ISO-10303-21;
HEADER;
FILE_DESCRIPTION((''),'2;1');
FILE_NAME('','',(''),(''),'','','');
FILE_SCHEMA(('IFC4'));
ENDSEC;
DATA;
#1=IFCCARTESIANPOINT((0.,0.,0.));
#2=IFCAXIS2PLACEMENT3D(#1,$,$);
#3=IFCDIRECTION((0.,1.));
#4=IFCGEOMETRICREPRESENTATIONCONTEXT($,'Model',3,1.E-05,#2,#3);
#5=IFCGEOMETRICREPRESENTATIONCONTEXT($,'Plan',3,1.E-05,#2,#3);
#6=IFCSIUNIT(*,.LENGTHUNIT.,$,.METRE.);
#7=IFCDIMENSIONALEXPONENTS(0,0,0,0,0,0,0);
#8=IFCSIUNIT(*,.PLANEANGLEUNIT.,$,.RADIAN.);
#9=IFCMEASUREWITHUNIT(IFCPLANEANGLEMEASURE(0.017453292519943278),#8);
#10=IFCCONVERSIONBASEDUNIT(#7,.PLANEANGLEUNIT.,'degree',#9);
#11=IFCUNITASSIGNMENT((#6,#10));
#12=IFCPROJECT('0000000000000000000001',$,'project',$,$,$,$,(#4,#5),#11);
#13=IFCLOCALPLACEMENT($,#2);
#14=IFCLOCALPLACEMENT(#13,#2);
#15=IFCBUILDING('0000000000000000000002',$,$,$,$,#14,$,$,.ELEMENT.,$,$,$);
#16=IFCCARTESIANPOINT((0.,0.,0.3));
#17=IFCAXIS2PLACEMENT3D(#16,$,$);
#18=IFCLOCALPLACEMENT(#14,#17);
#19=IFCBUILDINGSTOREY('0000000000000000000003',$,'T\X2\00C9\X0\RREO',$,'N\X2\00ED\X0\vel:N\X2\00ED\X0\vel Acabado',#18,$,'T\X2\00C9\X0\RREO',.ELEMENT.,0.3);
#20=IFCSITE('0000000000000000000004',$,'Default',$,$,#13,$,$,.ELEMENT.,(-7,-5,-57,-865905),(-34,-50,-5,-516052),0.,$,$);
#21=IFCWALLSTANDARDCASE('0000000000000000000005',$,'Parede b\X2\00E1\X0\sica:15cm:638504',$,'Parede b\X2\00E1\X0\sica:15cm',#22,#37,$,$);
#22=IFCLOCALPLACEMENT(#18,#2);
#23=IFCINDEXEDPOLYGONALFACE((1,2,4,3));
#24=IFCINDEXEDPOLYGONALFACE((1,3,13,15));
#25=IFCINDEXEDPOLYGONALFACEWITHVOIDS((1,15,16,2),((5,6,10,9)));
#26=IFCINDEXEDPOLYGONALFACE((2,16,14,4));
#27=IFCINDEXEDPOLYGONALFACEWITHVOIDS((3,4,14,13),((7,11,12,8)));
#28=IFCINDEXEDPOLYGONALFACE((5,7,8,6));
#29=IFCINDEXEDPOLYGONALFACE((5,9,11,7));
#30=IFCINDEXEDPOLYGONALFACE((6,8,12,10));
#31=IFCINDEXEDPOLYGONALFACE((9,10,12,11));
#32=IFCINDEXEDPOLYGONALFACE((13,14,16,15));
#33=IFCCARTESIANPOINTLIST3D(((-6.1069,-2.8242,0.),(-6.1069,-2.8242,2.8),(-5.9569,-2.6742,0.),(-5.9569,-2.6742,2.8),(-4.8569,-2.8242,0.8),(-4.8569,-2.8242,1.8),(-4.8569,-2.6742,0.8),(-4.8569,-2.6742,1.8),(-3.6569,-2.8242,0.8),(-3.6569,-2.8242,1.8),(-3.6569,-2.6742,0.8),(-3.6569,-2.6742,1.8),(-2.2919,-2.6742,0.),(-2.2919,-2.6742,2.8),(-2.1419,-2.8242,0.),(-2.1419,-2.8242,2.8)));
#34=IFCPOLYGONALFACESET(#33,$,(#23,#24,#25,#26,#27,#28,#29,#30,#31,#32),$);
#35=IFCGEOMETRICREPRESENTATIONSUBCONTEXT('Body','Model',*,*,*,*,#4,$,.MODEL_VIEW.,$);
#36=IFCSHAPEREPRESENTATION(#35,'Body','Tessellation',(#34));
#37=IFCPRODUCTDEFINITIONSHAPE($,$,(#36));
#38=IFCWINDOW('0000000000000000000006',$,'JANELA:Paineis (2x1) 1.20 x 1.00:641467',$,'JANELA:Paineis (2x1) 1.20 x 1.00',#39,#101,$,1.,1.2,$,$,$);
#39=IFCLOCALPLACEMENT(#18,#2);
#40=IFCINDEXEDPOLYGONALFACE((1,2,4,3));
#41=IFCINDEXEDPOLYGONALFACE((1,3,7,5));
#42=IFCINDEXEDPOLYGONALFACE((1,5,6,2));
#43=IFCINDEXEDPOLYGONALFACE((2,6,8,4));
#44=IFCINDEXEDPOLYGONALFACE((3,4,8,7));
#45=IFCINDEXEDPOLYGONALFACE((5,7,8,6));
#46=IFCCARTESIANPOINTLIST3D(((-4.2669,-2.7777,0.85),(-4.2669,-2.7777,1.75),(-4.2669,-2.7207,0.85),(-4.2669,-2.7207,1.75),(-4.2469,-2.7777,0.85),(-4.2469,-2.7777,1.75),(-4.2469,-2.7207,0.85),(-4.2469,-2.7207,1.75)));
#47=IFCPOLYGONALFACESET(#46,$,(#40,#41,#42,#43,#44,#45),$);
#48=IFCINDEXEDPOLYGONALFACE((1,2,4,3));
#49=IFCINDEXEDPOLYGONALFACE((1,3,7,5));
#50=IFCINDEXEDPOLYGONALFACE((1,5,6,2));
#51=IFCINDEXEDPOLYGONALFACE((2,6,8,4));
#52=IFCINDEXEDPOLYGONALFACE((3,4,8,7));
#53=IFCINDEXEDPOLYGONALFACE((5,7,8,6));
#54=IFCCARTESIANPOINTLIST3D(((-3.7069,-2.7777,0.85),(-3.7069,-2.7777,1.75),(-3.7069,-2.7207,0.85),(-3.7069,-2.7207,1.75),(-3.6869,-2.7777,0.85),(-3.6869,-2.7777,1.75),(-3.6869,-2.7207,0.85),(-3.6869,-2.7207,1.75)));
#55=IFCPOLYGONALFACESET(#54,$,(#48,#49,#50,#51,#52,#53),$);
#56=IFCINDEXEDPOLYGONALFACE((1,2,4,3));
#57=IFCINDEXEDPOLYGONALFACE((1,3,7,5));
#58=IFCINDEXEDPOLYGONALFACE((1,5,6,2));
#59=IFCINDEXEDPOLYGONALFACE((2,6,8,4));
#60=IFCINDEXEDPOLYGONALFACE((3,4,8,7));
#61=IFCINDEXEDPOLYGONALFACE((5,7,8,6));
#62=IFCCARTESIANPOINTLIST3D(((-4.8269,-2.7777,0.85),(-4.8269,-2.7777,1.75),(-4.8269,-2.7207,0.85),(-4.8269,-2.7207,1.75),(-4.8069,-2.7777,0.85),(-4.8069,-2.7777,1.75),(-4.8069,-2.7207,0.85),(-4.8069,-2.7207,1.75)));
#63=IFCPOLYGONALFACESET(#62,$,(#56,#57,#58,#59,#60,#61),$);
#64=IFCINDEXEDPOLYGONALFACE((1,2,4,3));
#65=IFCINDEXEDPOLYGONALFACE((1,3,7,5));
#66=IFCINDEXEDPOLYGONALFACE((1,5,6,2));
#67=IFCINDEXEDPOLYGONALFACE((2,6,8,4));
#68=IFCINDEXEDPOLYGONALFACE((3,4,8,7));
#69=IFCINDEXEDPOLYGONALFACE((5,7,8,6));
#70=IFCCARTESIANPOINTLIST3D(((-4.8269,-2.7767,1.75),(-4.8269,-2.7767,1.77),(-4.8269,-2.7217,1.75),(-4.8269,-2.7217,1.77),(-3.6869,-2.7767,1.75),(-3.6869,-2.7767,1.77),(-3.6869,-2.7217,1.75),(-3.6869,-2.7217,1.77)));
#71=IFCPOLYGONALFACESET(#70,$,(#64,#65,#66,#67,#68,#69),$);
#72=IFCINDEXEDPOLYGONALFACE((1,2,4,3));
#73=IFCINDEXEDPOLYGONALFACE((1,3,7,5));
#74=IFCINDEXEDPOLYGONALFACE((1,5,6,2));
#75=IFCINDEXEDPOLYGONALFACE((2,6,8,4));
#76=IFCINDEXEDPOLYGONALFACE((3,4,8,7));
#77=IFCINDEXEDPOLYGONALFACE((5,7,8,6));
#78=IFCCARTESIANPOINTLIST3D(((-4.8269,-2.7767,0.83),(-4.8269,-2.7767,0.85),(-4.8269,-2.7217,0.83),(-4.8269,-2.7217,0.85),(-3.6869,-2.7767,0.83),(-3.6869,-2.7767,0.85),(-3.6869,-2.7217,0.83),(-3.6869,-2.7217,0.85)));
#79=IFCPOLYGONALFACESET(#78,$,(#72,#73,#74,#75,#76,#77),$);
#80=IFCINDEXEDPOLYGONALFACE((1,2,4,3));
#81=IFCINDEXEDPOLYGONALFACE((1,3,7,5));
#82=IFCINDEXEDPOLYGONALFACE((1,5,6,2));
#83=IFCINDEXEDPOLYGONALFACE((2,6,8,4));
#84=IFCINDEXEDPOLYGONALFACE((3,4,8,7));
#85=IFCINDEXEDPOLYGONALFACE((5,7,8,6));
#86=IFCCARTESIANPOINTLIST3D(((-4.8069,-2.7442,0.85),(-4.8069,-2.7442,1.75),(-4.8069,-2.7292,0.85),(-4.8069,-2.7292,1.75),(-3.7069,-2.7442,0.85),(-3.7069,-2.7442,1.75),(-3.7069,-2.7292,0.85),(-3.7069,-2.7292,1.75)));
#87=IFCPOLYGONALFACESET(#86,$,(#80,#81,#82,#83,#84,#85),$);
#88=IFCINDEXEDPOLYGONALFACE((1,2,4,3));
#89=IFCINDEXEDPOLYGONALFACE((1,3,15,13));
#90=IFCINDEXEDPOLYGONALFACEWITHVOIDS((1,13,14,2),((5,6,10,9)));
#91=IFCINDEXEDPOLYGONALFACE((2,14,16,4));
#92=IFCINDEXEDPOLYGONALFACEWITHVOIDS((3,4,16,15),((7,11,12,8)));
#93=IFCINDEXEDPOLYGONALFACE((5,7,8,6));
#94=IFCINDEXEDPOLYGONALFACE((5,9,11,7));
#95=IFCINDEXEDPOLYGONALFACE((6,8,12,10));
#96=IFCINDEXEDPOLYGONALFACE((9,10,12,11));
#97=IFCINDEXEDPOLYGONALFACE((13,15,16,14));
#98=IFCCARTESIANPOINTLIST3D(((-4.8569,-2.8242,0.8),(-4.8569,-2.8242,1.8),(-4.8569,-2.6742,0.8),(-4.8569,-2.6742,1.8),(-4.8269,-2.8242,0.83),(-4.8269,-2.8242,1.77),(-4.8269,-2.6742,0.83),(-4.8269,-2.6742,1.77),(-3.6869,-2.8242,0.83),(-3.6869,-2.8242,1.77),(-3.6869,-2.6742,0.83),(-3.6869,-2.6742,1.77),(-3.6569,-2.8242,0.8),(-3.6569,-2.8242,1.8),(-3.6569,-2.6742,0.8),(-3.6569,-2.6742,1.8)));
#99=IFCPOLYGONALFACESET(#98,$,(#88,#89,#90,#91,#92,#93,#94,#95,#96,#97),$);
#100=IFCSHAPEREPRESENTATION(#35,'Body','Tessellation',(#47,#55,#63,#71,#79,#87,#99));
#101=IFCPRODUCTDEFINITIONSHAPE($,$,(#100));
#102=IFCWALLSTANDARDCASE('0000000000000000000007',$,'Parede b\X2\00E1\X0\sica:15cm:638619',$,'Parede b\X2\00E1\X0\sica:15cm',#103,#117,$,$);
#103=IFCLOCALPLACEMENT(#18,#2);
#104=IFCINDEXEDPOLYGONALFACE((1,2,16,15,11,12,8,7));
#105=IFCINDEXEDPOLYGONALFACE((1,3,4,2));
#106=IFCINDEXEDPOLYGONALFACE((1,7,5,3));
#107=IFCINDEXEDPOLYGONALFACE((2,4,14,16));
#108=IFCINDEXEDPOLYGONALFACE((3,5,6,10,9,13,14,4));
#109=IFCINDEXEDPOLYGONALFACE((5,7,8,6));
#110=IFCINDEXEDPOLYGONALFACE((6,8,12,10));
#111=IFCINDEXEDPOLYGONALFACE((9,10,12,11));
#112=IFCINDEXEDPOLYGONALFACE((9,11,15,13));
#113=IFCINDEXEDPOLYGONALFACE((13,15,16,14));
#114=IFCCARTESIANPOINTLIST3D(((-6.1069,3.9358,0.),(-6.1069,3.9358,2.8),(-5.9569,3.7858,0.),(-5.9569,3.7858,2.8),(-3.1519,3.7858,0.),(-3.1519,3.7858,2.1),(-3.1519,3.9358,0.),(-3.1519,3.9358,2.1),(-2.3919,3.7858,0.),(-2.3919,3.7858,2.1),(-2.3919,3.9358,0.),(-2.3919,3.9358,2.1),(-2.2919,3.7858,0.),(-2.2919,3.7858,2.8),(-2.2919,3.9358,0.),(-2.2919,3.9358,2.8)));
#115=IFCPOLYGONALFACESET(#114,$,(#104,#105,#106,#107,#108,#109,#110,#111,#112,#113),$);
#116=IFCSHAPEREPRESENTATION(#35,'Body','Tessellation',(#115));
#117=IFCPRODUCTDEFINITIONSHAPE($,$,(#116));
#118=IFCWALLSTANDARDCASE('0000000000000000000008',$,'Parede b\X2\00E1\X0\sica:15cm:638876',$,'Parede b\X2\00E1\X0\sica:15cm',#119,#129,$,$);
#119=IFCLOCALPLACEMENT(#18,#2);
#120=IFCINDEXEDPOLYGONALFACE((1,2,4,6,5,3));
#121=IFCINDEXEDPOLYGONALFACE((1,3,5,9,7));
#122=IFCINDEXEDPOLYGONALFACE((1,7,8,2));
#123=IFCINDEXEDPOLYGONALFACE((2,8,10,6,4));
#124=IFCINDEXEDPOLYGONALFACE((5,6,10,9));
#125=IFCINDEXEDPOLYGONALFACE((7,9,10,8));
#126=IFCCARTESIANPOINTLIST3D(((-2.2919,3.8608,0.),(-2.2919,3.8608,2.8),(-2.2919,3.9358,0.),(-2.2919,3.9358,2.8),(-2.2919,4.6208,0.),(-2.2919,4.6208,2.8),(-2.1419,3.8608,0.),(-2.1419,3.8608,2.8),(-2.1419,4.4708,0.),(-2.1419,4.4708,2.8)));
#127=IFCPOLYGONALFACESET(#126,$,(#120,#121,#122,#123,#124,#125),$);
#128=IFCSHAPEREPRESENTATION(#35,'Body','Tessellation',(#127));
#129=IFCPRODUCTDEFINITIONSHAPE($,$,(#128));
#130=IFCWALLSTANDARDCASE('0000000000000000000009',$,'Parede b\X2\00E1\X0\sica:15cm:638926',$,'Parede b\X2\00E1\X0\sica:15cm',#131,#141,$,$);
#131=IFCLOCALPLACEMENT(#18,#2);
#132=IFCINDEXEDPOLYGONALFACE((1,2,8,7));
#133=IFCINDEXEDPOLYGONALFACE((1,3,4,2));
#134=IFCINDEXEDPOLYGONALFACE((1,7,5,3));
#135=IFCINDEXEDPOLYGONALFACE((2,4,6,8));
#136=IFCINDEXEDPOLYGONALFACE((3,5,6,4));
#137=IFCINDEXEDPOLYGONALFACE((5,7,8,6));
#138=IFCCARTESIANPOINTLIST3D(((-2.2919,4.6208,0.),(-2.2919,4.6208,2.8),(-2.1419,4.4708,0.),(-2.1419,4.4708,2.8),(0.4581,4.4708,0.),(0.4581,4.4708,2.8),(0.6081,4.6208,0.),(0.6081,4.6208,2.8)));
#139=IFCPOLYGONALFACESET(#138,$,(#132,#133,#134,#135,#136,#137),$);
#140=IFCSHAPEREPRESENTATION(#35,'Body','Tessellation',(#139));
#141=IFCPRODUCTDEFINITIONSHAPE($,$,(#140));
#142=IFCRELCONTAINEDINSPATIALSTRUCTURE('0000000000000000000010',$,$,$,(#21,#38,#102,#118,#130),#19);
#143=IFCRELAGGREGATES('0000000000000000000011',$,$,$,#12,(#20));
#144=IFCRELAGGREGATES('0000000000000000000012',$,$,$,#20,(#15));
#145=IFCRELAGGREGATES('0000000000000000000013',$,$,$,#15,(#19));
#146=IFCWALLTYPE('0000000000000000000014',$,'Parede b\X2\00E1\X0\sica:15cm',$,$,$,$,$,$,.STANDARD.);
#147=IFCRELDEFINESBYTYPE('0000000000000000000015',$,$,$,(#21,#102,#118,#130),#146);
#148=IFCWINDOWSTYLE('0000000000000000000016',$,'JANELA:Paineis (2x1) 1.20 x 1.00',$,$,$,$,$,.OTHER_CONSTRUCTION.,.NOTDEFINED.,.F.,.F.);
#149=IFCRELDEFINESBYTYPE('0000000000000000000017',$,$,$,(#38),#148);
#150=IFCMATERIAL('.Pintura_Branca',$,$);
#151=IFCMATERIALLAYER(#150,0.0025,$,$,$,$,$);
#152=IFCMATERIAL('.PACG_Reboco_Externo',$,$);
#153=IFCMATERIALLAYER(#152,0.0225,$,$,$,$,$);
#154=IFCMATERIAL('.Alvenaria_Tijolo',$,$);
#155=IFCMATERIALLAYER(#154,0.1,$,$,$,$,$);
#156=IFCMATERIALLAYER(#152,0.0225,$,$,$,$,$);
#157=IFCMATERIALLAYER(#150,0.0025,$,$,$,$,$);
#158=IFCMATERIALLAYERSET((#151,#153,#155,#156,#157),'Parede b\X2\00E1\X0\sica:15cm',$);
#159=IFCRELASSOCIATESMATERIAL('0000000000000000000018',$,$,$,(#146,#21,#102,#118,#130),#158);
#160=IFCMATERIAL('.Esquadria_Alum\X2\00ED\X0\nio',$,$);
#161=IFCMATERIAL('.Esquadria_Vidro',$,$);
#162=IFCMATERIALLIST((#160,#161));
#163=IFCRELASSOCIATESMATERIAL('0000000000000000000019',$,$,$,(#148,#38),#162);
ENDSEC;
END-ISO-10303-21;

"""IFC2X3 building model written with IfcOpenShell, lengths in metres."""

from ifc_helpers import new_model, entity, si_unit, converted_unit, direction, frame, frame_2d, origin, origin_2d_with_axis, place, context, subcontext, project, spatial, polyline, rectangle, outline, extrude, source, transform, mapped, material, material_list, layer, layer_set, layer_usage, type_object, type_shapes, element, fill, save


model = new_model("IFC2X3")

# Units and contexts
model_context = context("Model", 3, precision=1e-05, world=origin(), true_north=direction((0.0, 1.0)))
plan_context = context("Plan", 3, precision=1e-05, world=origin(), true_north=direction((0.0, 1.0)))
body_context = subcontext(model_context, "Body", "Model", "MODEL_VIEW")
ifc_project = project(units=[si_unit("LENGTHUNIT", "METRE"), converted_unit("PLANEANGLEUNIT", "degree", entity("IfcPlaneAngleMeasure", 0.017453292519943278), si_unit("PLANEANGLEUNIT", "RADIAN"), dimensions=[0, 0, 0, 0, 0, 0, 0])], contexts=[model_context, plan_context])

# Site, building, storey
site_placement = place(None, origin())
site = spatial("IfcSite", under=ifc_project, at=site_placement, Name="Default", CompositionType="ELEMENT", RefLatitude=(-7, -5, -57, -865905), RefLongitude=(-34, -50, -5, -516052), RefElevation=0.0)
building_placement = place(site_placement, origin())
building = spatial("IfcBuilding", under=site, at=building_placement, CompositionType="ELEMENT")
storey_placement = place(building_placement, frame((0.0, 0.0, 0.3)))
storey = spatial("IfcBuildingStorey", under=building, at=storey_placement, Name="TÉRREO", ObjectType="Nível:Nível Acabado", LongName="TÉRREO", CompositionType="ELEMENT", Elevation=0.3)

# Shared definitions
ifc_material_1 = material(Name=".Pintura_Branca")
ifc_layer_1 = layer(ifc_material_1, 0.0025)
ifc_material_2 = material(Name=".PACG_Reboco_Externo")
ifc_layer_2 = layer(ifc_material_2, 0.0225)
ifc_material_3 = material(Name=".Alvenaria_Tijolo")
ifc_layer_3 = layer(ifc_material_3, 0.1)
ifc_layer_4 = layer(ifc_material_2, 0.0225)
ifc_layer_5 = layer(ifc_material_1, 0.0025)
ifc_layer_set_1 = layer_set([ifc_layer_1, ifc_layer_2, ifc_layer_3, ifc_layer_4, ifc_layer_5], Name="Parede básica:15cm")
wall_type = type_object("IfcWallType", Name="Parede básica:15cm", PredefinedType="STANDARD", material=ifc_layer_set_1)
ifc_material_4 = material(Name=".Esquadria_Alumínio")
ifc_material_5 = material(Name=".Esquadria_Vidro")
ifc_material_list = material_list([ifc_material_4, ifc_material_5])
window_style_1 = type_object("IfcWindowStyle", Name="JANELA:Paineis (2x1) 1.20 x 1.00", ConstructionType="OTHER_CONSTRUCTION", OperationType="NOTDEFINED", ParameterTakesPrecedence=False, Sizeable=False, material=ifc_material_list)
shared_shape_1 = source(origin(), body_context, "Body", "SweptSolid", [
    extrude(rectangle(XDim=0.02, YDim=0.057, at=origin_2d_with_axis()), frame((0.6, 0.075, 0.05), z_axis=(0.0, 0.0, 1.0), x_axis=(-1.0, 0.0, 0.0)), (0.0, 0.0, 1.0), 0.9),
    extrude(rectangle(XDim=0.02, YDim=0.057, at=frame_2d((0.0, 0.0), x_axis=(1.0, 0.0))), frame((0.04, 0.075, 0.05), z_axis=(0.0, 0.0, 1.0), x_axis=(-1.0, 0.0, 0.0)), (0.0, 0.0, 1.0), 0.9),
    extrude(rectangle(XDim=0.02, YDim=0.057, at=frame_2d((0.0, 0.0), x_axis=(1.0, 0.0))), frame((1.16, 0.075, 0.05), z_axis=(0.0, 0.0, 1.0), x_axis=(-1.0, 0.0, 0.0)), (0.0, 0.0, 1.0), 0.9),
    extrude(rectangle(XDim=1.14, YDim=0.055, at=frame_2d((0.0, 0.0), x_axis=(1.0, 0.0))), frame((0.6, 0.075, 0.95), z_axis=(0.0, 0.0, 1.0), x_axis=(-1.0, 0.0, 0.0)), (0.0, 0.0, 1.0), 0.02),
    extrude(rectangle(XDim=1.14, YDim=0.055, at=frame_2d((0.0, 0.0), x_axis=(1.0, 0.0))), frame((0.6, 0.075, 0.03), z_axis=(0.0, 0.0, 1.0), x_axis=(-1.0, 0.0, 0.0)), (0.0, 0.0, 1.0), 0.02),
    extrude(rectangle(XDim=0.015, YDim=1.1, at=frame_2d((0.0, 0.0), x_axis=(1.0, 0.0))), frame((0.6, 0.0625, 0.05), z_axis=(0.0, 0.0, 1.0), x_axis=(0.0, 1.0, 0.0)), (0.0, 0.0, 1.0), 0.9),
    extrude(outline(polyline([(-0.6, -0.5), (0.6, -0.5), (0.6, 0.5), (-0.6, 0.5), (-0.6, -0.5)]), holes=[polyline([(0.57, -0.47), (-0.57, -0.47), (-0.57, 0.47), (0.57, 0.47), (0.57, -0.47)])]), frame((0.6, 0.0, 0.5), z_axis=(0.0, 1.0, 0.0), x_axis=(1.0, 0.0, 0.0)), (0.0, 0.0, 1.0), 0.15),
])
type_shapes(window_style_1, [shared_shape_1])

# Wall, opening, window
ifc_layer_usage_1 = layer_usage(ifc_layer_set_1, "AXIS2", "NEGATIVE", 0.075)
wall_1_placement = place(storey_placement, frame((-6.1069, -2.7492, 0.0)))
wall_1 = element("IfcWallStandardCase", 1, at=wall_1_placement, inside=storey, type_object=wall_type, material=ifc_layer_usage_1, Name="Parede básica:15cm:638504", ObjectType="Parede básica:15cm", context=body_context, shape_type="SweptSolid", body=[
    extrude(outline(polyline([(3.965, -0.075), (3.815, 0.075), (0.15, 0.075), (0.0, -0.075), (3.965, -0.075)])), origin(), (0.0, 0.0, 1.0), 2.8),
])
opening_1_placement = place(wall_1_placement, frame((2.45, 0.075, 0.8)))
opening_1 = element("IfcOpeningElement", 2, at=opening_1_placement, cuts=wall_1, ObjectType="Opening", context=body_context, shape_type="SweptSolid", body=[
    extrude(rectangle(XDim=1.0, YDim=1.2, at=frame_2d((0.5, 0.6), x_axis=(1.0, 0.0))), frame((0.0, 0.0, 0.0), z_axis=(0.0, -1.0, 0.0), x_axis=(0.0, 0.0, 1.0)), (0.0, 0.0, 1.0), 0.15),
])
window_1_placement = place(opening_1_placement, frame((0.0, 0.0, 0.0), z_axis=(0.0, 0.0, 1.0), x_axis=(-1.0, 0.0, 0.0)))
window_1 = element("IfcWindow", 3, at=window_1_placement, inside=storey, type_object=window_style_1, material=ifc_material_list, Name="JANELA:Paineis (2x1) 1.20 x 1.00:641467", ObjectType="JANELA:Paineis (2x1) 1.20 x 1.00", OverallHeight=1.0, OverallWidth=1.2, context=body_context, shape_type="MappedRepresentation", body=[
    mapped(shared_shape_1, transform((0.0, 0.0, 0.0), scale=1.0)),
])
fill(opening_1, window_1)

# Wall, opening
ifc_layer_usage_2 = layer_usage(ifc_layer_set_1, "AXIS2", "NEGATIVE", 0.075)
wall_2_placement = place(storey_placement, frame((-6.1069, 3.8608, 0.0)))
wall_2 = element("IfcWallStandardCase", 4, at=wall_2_placement, inside=storey, type_object=wall_type, material=ifc_layer_usage_2, Name="Parede básica:15cm:638619", ObjectType="Parede básica:15cm", context=body_context, shape_type="SweptSolid", body=[
    extrude(outline(polyline([(0.15, -0.075), (2.53, -0.075), (2.68, -0.075), (3.815, -0.075), (3.815, 0.0), (3.815, 0.075), (0.0, 0.075), (0.15, -0.075)])), origin(), (0.0, 0.0, 1.0), 2.8),
])
opening_2_placement = place(wall_2_placement, frame((2.955, -0.075, 0.0)))
element("IfcOpeningElement", 5, at=opening_2_placement, cuts=wall_2, ObjectType="Opening", context=body_context, shape_type="SweptSolid", body=[
    extrude(rectangle(XDim=0.76, YDim=2.1, at=frame_2d((1.05, 0.38), x_axis=(0.0, 1.0))), frame((0.0, 0.0, 0.0), z_axis=(0.0, 1.0, 0.0), x_axis=(0.0, 0.0, 1.0)), (0.0, 0.0, 1.0), 0.15),
])

# Walls
ifc_layer_usage_3 = layer_usage(ifc_layer_set_1, "AXIS2", "NEGATIVE", 0.075)
wall_3_placement = place(storey_placement, frame((-2.2169, 3.8608, 0.0), z_axis=(0.0, 0.0, 1.0), x_axis=(0.0, 1.0, 0.0)))
element("IfcWallStandardCase", 6, at=wall_3_placement, inside=storey, type_object=wall_type, material=ifc_layer_usage_3, Name="Parede básica:15cm:638876", ObjectType="Parede básica:15cm", context=body_context, shape_type="SweptSolid", body=[
    extrude(outline(polyline([(0.61, -0.075), (0.76, 0.075), (0.075, 0.075), (0.0, 0.075), (0.0, -0.075), (0.61, -0.075)])), origin(), (0.0, 0.0, 1.0), 2.8),
])
ifc_layer_usage_4 = layer_usage(ifc_layer_set_1, "AXIS2", "NEGATIVE", 0.075)
wall_4_placement = place(storey_placement, frame((-2.2919, 4.5458, 0.0)))
element("IfcWallStandardCase", 7, at=wall_4_placement, inside=storey, type_object=wall_type, material=ifc_layer_usage_4, Name="Parede básica:15cm:638926", ObjectType="Parede básica:15cm", context=body_context, shape_type="SweptSolid", body=[
    extrude(outline(polyline([(2.75, -0.075), (2.9, 0.075), (0.0, 0.075), (0.15, -0.075), (2.75, -0.075)])), origin(), (0.0, 0.0, 1.0), 2.8),
])

save(model, "model.ifc")
